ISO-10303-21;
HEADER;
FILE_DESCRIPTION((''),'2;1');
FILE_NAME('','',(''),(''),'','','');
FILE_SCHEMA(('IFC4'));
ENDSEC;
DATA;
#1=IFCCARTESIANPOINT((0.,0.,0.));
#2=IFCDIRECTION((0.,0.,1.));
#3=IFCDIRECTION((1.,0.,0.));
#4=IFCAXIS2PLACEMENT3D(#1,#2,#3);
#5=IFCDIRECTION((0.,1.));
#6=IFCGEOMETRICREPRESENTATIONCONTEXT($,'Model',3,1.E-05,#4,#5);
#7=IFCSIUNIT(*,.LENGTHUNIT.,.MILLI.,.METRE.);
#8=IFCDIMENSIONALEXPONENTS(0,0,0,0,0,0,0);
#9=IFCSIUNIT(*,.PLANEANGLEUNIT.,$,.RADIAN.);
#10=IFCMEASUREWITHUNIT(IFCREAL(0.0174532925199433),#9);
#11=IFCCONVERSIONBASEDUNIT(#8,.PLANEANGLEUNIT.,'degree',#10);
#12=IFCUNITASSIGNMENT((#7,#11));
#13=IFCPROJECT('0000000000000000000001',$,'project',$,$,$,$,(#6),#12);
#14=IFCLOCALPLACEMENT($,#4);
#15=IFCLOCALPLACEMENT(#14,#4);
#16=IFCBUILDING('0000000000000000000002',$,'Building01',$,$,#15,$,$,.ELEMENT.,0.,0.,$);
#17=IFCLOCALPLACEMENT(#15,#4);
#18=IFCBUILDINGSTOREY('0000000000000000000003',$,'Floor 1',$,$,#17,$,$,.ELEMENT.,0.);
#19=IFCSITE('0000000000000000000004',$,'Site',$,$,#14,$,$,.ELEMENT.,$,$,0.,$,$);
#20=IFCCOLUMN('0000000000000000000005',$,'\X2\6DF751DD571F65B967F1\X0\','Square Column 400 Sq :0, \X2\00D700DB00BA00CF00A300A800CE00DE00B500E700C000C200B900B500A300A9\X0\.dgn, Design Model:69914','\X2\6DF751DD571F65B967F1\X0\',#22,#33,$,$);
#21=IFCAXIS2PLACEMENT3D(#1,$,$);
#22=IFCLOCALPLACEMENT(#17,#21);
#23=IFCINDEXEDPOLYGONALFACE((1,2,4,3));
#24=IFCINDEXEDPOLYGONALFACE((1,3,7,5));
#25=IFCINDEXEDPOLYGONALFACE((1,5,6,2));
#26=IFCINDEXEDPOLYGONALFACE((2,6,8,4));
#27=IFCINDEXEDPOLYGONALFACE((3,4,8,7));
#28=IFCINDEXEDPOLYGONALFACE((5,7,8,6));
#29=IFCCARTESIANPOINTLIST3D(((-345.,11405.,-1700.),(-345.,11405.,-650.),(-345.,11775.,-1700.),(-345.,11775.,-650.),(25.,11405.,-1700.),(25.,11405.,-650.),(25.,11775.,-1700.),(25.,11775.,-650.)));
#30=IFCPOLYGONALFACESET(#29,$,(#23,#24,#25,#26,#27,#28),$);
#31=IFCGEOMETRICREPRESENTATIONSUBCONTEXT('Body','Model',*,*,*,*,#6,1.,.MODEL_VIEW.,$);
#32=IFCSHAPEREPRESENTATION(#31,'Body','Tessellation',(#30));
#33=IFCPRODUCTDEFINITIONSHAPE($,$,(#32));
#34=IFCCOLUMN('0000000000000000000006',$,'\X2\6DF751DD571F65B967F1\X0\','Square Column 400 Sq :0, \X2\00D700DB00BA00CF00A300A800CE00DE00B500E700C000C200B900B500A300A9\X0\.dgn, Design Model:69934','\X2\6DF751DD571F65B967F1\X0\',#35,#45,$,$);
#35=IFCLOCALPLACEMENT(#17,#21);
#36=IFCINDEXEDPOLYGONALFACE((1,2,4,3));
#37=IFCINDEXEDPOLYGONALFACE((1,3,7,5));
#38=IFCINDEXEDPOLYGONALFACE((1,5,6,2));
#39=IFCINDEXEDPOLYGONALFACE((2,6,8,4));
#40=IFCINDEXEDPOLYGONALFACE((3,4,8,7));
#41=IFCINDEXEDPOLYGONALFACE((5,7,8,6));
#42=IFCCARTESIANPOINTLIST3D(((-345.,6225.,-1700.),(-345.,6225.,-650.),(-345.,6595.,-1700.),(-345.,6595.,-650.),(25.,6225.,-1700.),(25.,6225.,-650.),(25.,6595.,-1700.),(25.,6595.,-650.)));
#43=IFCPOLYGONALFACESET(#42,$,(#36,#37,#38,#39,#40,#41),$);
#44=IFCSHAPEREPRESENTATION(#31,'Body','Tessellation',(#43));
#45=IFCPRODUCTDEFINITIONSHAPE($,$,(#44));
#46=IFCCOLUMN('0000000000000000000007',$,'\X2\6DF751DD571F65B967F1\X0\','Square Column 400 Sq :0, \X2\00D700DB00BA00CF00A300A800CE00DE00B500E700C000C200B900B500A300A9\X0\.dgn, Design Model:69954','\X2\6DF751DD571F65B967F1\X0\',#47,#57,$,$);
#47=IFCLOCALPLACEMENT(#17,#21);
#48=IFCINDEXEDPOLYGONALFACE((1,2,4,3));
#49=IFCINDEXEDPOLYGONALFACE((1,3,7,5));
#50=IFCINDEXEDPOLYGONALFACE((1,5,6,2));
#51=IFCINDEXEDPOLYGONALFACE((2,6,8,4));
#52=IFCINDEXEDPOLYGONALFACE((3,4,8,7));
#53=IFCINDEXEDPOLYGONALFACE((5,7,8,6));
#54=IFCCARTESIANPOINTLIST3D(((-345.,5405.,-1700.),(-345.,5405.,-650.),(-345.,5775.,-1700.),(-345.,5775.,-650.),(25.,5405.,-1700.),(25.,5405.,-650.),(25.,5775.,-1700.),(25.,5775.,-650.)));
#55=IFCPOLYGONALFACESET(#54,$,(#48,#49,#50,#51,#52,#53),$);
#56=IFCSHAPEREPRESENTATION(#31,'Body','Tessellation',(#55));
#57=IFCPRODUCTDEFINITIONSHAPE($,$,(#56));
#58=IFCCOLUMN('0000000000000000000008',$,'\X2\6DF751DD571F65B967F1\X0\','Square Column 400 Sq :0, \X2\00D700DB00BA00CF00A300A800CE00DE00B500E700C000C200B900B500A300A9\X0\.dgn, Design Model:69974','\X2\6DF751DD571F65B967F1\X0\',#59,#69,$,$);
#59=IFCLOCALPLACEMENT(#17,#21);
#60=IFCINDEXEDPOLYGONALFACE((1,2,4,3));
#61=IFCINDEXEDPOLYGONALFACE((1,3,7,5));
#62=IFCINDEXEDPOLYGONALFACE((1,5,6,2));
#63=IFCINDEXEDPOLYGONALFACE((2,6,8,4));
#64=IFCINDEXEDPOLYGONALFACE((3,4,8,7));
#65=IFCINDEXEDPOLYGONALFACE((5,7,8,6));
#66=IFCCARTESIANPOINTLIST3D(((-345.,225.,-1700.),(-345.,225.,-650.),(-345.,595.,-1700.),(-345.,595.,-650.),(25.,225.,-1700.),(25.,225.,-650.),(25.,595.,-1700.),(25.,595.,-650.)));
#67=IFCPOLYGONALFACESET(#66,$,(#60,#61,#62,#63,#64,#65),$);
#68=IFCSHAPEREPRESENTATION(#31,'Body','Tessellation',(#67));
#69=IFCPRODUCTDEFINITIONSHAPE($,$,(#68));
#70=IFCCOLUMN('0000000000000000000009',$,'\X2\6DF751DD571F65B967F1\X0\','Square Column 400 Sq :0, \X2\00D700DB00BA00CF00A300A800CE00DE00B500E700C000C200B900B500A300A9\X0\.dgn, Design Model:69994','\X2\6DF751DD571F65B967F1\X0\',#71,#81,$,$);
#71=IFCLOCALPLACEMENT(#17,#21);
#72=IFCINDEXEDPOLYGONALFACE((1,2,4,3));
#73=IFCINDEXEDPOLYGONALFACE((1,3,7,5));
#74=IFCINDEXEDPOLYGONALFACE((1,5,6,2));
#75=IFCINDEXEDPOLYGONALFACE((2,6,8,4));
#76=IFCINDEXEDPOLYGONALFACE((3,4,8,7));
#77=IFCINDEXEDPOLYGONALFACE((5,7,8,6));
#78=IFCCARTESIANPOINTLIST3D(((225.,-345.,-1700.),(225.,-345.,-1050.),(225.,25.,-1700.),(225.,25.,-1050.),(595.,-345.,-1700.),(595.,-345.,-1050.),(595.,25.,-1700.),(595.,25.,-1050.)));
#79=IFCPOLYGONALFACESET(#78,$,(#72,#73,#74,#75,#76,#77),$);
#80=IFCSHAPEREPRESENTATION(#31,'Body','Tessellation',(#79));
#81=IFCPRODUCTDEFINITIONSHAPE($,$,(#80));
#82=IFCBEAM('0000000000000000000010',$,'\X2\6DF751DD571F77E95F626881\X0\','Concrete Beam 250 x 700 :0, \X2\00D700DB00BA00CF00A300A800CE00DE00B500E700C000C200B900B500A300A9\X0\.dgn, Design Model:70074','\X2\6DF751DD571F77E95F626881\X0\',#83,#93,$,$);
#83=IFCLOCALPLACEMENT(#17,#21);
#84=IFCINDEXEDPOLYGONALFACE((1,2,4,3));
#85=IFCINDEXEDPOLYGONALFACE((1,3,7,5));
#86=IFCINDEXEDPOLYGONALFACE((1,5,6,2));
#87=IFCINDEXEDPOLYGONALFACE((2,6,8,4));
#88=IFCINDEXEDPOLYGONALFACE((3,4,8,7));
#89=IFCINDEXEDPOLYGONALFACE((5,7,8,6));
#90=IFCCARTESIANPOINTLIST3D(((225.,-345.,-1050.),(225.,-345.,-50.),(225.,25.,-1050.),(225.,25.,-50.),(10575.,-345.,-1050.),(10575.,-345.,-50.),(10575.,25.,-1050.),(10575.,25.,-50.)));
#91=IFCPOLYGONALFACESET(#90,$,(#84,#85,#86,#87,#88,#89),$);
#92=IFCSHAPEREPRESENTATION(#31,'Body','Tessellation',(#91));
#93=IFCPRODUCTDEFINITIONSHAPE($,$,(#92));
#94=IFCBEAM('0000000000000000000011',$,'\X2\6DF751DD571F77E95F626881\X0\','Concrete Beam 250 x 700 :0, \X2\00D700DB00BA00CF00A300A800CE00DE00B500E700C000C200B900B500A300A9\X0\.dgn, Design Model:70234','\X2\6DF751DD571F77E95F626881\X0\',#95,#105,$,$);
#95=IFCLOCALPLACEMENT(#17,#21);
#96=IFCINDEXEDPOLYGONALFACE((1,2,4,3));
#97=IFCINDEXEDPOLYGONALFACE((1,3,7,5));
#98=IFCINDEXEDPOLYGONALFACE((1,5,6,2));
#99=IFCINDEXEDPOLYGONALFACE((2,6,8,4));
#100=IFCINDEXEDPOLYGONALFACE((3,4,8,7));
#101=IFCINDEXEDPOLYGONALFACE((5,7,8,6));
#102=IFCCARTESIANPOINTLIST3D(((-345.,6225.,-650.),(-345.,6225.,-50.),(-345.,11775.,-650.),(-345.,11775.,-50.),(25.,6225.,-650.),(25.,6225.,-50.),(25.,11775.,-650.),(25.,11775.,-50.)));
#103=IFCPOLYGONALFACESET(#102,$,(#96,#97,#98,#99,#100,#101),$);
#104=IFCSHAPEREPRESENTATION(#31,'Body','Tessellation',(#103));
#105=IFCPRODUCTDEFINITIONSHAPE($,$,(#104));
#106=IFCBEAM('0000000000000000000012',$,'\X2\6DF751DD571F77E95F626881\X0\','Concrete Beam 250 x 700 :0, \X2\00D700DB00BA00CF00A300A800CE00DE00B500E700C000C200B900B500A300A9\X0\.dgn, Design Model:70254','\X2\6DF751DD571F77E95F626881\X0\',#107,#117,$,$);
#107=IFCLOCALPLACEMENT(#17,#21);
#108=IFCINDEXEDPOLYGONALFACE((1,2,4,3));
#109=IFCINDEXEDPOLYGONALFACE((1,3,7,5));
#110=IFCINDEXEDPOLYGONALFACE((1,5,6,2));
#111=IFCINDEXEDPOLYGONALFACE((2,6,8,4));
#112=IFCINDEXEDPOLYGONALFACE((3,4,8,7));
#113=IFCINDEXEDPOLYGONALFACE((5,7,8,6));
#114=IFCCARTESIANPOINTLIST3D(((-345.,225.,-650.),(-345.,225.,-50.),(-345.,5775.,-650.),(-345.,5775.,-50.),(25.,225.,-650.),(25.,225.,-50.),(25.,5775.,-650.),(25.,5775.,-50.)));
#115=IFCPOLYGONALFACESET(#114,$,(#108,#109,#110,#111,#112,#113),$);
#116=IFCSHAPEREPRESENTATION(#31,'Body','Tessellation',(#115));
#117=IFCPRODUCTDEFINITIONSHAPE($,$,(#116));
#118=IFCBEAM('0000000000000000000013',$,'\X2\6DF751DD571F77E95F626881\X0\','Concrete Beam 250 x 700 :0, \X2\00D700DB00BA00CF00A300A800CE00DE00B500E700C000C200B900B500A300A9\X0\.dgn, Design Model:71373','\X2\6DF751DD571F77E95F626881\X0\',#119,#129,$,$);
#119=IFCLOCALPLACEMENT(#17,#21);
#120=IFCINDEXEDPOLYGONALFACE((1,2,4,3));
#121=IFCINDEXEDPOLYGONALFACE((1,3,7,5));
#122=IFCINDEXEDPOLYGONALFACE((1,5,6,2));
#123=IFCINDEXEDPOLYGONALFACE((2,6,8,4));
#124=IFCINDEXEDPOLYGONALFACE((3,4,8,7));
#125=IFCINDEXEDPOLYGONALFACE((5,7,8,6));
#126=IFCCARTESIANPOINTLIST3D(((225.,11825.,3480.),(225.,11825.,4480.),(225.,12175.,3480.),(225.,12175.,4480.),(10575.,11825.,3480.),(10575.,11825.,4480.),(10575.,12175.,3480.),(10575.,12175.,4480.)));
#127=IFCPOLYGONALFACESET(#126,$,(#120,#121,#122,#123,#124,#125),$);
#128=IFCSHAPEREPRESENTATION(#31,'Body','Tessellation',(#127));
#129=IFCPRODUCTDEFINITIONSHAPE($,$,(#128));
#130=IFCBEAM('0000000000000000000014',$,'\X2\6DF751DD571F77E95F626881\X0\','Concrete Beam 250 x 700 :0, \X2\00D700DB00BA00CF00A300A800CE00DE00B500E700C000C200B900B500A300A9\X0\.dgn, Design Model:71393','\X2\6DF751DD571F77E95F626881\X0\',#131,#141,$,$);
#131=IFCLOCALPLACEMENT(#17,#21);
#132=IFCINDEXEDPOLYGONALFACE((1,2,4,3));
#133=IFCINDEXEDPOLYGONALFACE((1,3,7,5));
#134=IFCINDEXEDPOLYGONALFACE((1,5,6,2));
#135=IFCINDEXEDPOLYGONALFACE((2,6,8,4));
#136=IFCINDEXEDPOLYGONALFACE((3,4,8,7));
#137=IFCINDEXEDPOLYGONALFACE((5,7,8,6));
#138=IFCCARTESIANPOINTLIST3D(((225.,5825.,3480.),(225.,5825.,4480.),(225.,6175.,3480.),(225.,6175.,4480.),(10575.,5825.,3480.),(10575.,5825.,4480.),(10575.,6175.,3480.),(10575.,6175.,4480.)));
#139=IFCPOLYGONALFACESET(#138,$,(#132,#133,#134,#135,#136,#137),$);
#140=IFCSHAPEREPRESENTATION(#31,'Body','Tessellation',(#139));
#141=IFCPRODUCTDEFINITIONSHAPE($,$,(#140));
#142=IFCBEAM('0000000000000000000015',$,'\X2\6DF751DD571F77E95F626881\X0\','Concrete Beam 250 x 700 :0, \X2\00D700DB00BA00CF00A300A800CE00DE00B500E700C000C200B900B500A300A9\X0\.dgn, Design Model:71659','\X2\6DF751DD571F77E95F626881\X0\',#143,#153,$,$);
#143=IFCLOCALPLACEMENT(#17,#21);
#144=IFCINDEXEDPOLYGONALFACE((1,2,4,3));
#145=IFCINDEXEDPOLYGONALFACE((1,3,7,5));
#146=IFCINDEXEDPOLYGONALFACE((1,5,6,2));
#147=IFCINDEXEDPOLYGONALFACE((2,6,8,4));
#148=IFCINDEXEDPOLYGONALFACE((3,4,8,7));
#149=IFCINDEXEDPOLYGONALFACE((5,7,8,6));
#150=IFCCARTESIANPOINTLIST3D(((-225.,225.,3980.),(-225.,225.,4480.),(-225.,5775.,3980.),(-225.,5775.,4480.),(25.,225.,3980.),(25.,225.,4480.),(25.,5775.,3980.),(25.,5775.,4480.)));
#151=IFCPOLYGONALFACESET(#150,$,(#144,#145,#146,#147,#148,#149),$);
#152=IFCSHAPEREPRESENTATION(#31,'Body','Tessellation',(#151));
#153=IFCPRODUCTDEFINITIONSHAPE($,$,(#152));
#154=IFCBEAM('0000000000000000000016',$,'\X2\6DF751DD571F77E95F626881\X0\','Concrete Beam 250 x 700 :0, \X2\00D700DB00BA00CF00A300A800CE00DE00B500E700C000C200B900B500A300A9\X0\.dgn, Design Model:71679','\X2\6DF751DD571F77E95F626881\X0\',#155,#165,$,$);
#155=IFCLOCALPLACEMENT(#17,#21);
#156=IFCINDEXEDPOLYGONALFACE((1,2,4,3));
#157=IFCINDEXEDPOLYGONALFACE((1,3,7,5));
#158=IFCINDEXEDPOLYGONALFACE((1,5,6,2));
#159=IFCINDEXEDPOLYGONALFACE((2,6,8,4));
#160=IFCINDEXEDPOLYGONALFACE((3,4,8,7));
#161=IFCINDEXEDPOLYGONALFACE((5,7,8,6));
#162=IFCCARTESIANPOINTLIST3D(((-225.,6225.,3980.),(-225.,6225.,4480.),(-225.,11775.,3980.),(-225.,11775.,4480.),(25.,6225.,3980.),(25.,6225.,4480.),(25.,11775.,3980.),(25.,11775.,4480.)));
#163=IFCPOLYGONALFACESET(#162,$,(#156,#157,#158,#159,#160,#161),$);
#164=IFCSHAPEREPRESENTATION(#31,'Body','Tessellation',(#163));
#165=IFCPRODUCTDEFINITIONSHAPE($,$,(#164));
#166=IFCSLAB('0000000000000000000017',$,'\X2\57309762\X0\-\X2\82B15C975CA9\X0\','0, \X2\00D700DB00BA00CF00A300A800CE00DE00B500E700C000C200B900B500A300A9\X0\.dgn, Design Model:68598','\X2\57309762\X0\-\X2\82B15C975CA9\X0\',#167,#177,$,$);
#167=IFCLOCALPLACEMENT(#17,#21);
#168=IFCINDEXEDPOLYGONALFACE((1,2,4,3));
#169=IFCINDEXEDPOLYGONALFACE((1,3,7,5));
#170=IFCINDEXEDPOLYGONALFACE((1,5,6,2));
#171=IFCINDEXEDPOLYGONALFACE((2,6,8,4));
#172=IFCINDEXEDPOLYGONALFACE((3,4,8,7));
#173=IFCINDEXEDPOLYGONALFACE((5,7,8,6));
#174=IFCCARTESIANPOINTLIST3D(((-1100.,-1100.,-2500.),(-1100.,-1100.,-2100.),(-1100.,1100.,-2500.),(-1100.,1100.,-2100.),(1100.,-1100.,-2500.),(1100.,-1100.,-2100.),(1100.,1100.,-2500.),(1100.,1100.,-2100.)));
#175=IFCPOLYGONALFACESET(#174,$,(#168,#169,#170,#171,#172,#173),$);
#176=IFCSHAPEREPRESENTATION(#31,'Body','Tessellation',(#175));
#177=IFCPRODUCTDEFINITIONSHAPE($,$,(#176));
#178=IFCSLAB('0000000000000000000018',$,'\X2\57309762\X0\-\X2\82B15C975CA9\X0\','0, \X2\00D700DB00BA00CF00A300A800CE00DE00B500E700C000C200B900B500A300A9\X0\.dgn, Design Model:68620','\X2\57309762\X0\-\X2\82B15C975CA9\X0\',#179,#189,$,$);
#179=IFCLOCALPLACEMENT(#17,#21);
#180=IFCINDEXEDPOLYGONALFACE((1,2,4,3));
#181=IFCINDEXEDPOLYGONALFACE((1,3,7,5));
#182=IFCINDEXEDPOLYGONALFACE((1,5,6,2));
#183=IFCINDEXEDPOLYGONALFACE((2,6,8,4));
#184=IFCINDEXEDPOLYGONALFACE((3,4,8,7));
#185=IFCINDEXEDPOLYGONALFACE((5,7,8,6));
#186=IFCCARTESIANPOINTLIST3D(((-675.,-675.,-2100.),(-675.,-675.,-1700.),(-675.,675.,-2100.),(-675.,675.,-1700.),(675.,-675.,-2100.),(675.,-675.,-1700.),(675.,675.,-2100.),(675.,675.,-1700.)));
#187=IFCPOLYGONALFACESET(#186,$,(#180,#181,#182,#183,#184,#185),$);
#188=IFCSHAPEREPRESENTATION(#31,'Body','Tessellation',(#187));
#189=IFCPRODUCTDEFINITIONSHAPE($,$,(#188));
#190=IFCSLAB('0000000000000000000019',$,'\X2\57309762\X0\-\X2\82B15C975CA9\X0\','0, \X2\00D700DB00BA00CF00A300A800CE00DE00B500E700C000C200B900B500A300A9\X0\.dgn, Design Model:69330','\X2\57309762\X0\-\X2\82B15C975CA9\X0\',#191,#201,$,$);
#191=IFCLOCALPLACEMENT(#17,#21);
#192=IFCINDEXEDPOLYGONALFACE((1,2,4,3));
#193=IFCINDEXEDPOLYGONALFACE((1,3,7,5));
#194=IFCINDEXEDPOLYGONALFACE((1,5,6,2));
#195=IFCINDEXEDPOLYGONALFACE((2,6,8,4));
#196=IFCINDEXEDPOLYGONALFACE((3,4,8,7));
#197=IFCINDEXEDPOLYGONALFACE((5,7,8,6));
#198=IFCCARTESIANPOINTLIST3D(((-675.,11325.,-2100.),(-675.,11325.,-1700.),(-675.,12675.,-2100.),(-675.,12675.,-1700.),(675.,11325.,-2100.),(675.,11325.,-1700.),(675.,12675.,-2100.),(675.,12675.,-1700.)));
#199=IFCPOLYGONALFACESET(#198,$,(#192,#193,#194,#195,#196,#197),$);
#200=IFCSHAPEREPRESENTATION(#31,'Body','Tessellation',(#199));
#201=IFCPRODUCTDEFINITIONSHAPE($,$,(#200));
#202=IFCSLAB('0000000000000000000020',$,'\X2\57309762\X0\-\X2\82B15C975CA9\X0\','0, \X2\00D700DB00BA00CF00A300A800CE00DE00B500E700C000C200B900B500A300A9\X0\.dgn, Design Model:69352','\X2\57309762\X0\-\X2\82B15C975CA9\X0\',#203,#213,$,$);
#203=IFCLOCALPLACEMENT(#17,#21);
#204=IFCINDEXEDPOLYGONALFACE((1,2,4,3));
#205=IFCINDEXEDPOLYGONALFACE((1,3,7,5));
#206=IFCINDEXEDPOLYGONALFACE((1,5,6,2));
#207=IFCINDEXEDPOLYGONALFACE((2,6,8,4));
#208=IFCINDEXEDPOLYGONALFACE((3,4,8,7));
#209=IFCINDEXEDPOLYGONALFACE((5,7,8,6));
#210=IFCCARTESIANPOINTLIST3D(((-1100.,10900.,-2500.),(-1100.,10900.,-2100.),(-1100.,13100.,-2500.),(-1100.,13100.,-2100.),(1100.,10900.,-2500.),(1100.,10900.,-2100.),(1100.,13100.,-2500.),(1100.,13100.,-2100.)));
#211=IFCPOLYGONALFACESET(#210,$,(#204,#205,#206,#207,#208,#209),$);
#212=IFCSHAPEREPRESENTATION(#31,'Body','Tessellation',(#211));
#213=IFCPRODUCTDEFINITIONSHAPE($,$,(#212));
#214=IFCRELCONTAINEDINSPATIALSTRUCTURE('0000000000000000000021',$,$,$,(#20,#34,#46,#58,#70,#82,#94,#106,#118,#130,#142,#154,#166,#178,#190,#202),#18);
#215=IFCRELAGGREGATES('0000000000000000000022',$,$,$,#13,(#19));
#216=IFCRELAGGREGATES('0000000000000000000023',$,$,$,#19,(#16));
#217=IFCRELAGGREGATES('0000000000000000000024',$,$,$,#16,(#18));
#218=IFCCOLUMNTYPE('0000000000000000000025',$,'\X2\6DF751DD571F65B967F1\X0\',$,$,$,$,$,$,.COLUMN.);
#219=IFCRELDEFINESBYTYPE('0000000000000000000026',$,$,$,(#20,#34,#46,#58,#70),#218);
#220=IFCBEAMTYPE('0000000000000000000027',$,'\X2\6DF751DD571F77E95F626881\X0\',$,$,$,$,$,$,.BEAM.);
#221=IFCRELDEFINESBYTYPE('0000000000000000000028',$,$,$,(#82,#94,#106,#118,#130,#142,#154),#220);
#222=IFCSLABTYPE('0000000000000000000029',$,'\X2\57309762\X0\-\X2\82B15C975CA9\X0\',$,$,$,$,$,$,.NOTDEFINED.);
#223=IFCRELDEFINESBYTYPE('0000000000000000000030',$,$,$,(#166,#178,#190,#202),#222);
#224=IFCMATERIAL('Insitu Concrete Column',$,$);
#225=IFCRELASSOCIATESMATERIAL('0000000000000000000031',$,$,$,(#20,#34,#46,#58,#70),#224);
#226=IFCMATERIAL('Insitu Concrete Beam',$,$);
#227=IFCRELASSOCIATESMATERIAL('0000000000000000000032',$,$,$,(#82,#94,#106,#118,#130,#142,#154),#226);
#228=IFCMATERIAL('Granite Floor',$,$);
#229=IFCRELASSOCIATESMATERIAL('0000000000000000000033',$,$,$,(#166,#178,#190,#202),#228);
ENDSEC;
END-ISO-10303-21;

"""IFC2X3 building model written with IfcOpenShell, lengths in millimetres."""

from ifc_helpers import new_model, entity, si_unit, converted_unit, direction, frame, frame_2d, origin_with_axes, place, context, subcontext, project, spatial, rectangle, extrude, material, type_object, element, save


model = new_model("IFC2X3")

# Units and contexts
model_context = context("Model", 3, precision=1e-05, world=origin_with_axes(), true_north=direction((0.0, 1.0)))
body_context = subcontext(model_context, "Body", "Model", "MODEL_VIEW", scale=1.0)
ifc_project = project(units=[si_unit("LENGTHUNIT", "METRE", prefix="MILLI"), converted_unit("PLANEANGLEUNIT", "degree", entity("IfcReal", 0.0174532925199433), si_unit("PLANEANGLEUNIT", "RADIAN"), dimensions=[0, 0, 0, 0, 0, 0, 0])], contexts=[model_context])

# Site, building, storey
site_placement = place(None, origin_with_axes())
site = spatial("IfcSite", under=ifc_project, at=site_placement, Name="Site", CompositionType="ELEMENT", RefElevation=0.0)
building_placement = place(site_placement, origin_with_axes())
building = spatial("IfcBuilding", under=site, at=building_placement, Name="Building01", CompositionType="ELEMENT", ElevationOfRefHeight=0.0, ElevationOfTerrain=0.0)
storey_placement = place(building_placement, origin_with_axes())
storey = spatial("IfcBuildingStorey", under=building, at=storey_placement, Name="Floor 1", CompositionType="ELEMENT", Elevation=0.0)

# Columns
ifc_material_1 = material(Name="Insitu Concrete Column")
column_type = type_object("IfcColumnType", Name="混凝土方柱", PredefinedType="COLUMN")
for number, where, z_axis, x_axis, name, description in (
    (1, (25.0, 11405.0, -1700.0), (0.0, 0.0, 1.0), (0.0, 1.0, 0.0), "混凝土方柱", "Square Column 400 Sq :0, ×ÛºÏ£¨ÎÞµçÀÂ¹µ£©.dgn, Design Model:69914"),
    (2, (25.0, 6595.0, -1700.0), (0.0, 0.0, 1.0), (-1.0, 0.0, 0.0), "混凝土方柱", "Square Column 400 Sq :0, ×ÛºÏ£¨ÎÞµçÀÂ¹µ£©.dgn, Design Model:69934"),
    (3, (25.0, 5405.0, -1700.0), (0.0, 0.0, 1.0), (0.0, 1.0, 0.0), "混凝土方柱", "Square Column 400 Sq :0, ×ÛºÏ£¨ÎÞµçÀÂ¹µ£©.dgn, Design Model:69954"),
    (4, (25.0, 595.0, -1700.0), (0.0, 0.0, 1.0), (-1.0, 0.0, 0.0), "混凝土方柱", "Square Column 400 Sq :0, ×ÛºÏ£¨ÎÞµçÀÂ¹µ£©.dgn, Design Model:69974"),
):
    element("IfcColumn", number, at=place(storey_placement, frame(where, z_axis=z_axis, x_axis=x_axis)), inside=storey, type_object=column_type, material=ifc_material_1, Name=name, Description=description, ObjectType="混凝土方柱", context=body_context, shape_type="SweptSolid", body=[
        extrude(rectangle(XDim=370.0, YDim=370.0, at=frame_2d((185.0, 185.0), x_axis=(0.0, 1.0))), origin_with_axes(), (0.0, 0.0, 1.0), 1050.0),
    ])
column_placement = place(storey_placement, frame((225.0, 25.0, -1700.0), z_axis=(0.0, 0.0, 1.0), x_axis=(0.0, -1.0, 0.0)))
element("IfcColumn", 5, at=column_placement, inside=storey, type_object=column_type, material=ifc_material_1, Name="混凝土方柱", Description="Square Column 400 Sq :0, ×ÛºÏ£¨ÎÞµçÀÂ¹µ£©.dgn, Design Model:69994", ObjectType="混凝土方柱", context=body_context, shape_type="SweptSolid", body=[
    extrude(rectangle(XDim=370.0, YDim=370.0, at=frame_2d((185.0, 185.0), x_axis=(0.0, 1.0))), origin_with_axes(), (0.0, 0.0, 1.0), 650.0),
])

# Beams
ifc_material_2 = material(Name="Insitu Concrete Beam")
beam_type = type_object("IfcBeamType", Name="混凝土矩形梁", PredefinedType="BEAM")
beam_placement = place(storey_placement, frame((225.0, -345.0, -1050.0), z_axis=(1.0, 0.0, 0.0), x_axis=(0.0, 1.0, 0.0)))
element("IfcBeam", 6, at=beam_placement, inside=storey, type_object=beam_type, material=ifc_material_2, Name="混凝土矩形梁", Description="Concrete Beam 250 x 700 :0, ×ÛºÏ£¨ÎÞµçÀÂ¹µ£©.dgn, Design Model:70074", ObjectType="混凝土矩形梁", context=body_context, shape_type="SweptSolid", body=[
    extrude(rectangle(XDim=1000.0, YDim=370.0, at=frame_2d((185.0, 500.0), x_axis=(0.0, 1.0))), origin_with_axes(), (0.0, 0.0, 1.0), 10350.0),
])
for number, where, z_axis, x_axis, name, description in (
    (7, (-345.0, 6225.0, -650.0), (0.0, 1.0, 0.0), (0.0, 0.0, 1.0), "混凝土矩形梁", "Concrete Beam 250 x 700 :0, ×ÛºÏ£¨ÎÞµçÀÂ¹µ£©.dgn, Design Model:70234"),
    (8, (-345.0, 225.0, -650.0), (0.0, 1.0, 0.0), (0.0, 0.0, 1.0), "混凝土矩形梁", "Concrete Beam 250 x 700 :0, ×ÛºÏ£¨ÎÞµçÀÂ¹µ£©.dgn, Design Model:70254"),
):
    element("IfcBeam", number, at=place(storey_placement, frame(where, z_axis=z_axis, x_axis=x_axis)), inside=storey, type_object=beam_type, material=ifc_material_2, Name=name, Description=description, ObjectType="混凝土矩形梁", context=body_context, shape_type="SweptSolid", body=[
        extrude(rectangle(XDim=370.0, YDim=600.0, at=frame_2d((300.0, 185.0), x_axis=(0.0, 1.0))), origin_with_axes(), (0.0, 0.0, 1.0), 5550.0),
    ])
for number, where, z_axis, x_axis, name, description in (
    (9, (225.0, 11825.0, 3480.0), (1.0, 0.0, 0.0), (0.0, 1.0, 0.0), "混凝土矩形梁", "Concrete Beam 250 x 700 :0, ×ÛºÏ£¨ÎÞµçÀÂ¹µ£©.dgn, Design Model:71373"),
    (10, (225.0, 5825.0, 3480.0), (1.0, 0.0, 0.0), (0.0, 1.0, 0.0), "混凝土矩形梁", "Concrete Beam 250 x 700 :0, ×ÛºÏ£¨ÎÞµçÀÂ¹µ£©.dgn, Design Model:71393"),
):
    element("IfcBeam", number, at=place(storey_placement, frame(where, z_axis=z_axis, x_axis=x_axis)), inside=storey, type_object=beam_type, material=ifc_material_2, Name=name, Description=description, ObjectType="混凝土矩形梁", context=body_context, shape_type="SweptSolid", body=[
        extrude(rectangle(XDim=1000.0, YDim=350.0, at=frame_2d((175.0, 500.0), x_axis=(0.0, 1.0))), origin_with_axes(), (0.0, 0.0, 1.0), 10350.0),
    ])
for number, where, z_axis, x_axis, name, description in (
    (11, (-225.0, 5775.0, 3980.0), (0.0, -1.0, 0.0), (1.0, 0.0, 0.0), "混凝土矩形梁", "Concrete Beam 250 x 700 :0, ×ÛºÏ£¨ÎÞµçÀÂ¹µ£©.dgn, Design Model:71659"),
    (12, (-225.0, 11775.0, 3980.0), (0.0, -1.0, 0.0), (1.0, 0.0, 0.0), "混凝土矩形梁", "Concrete Beam 250 x 700 :0, ×ÛºÏ£¨ÎÞµçÀÂ¹µ£©.dgn, Design Model:71679"),
):
    element("IfcBeam", number, at=place(storey_placement, frame(where, z_axis=z_axis, x_axis=x_axis)), inside=storey, type_object=beam_type, material=ifc_material_2, Name=name, Description=description, ObjectType="混凝土矩形梁", context=body_context, shape_type="SweptSolid", body=[
        extrude(rectangle(XDim=500.0, YDim=250.0, at=frame_2d((125.0, 250.0), x_axis=(0.0, 1.0))), origin_with_axes(), (0.0, 0.0, 1.0), 5550.0),
    ])

# Slabs
ifc_material_3 = material(Name="Granite Floor")
slab_type = type_object("IfcSlabType", Name="地面-花岗岩", PredefinedType="NOTDEFINED")
slab_1_placement = place(storey_placement, frame((-1100.0, -1100.0, -2500.0), z_axis=(0.0, 0.0, 1.0), x_axis=(1.0, 0.0, 0.0)))
element("IfcSlab", 13, at=slab_1_placement, inside=storey, type_object=slab_type, material=ifc_material_3, Name="地面-花岗岩", Description="0, ×ÛºÏ£¨ÎÞµçÀÂ¹µ£©.dgn, Design Model:68598", ObjectType="地面-花岗岩", context=body_context, shape_type="SweptSolid", body=[
    extrude(rectangle(XDim=2200.0, YDim=2200.0, at=frame_2d((1100.0, 1100.0), x_axis=(1.0, 0.0))), origin_with_axes(), (0.0, 0.0, 1.0), 400.0),
])
for number, where, z_axis, x_axis, name in (
    (14, (-675.0, -675.0, -2100.0), (0.0, 0.0, 1.0), (1.0, 0.0, 0.0), "地面-花岗岩"),
):
    element("IfcSlab", number, at=place(storey_placement, frame(where, z_axis=z_axis, x_axis=x_axis)), inside=storey, type_object=slab_type, material=ifc_material_3, Name=name, Description="0, ×ÛºÏ£¨ÎÞµçÀÂ¹µ£©.dgn, Design Model:68620", ObjectType="地面-花岗岩", context=body_context, shape_type="SweptSolid", body=[
        extrude(rectangle(XDim=1350.0, YDim=1350.0, at=frame_2d((675.0, 675.0), x_axis=(1.0, 0.0))), origin_with_axes(), (0.0, 0.0, 1.0), 400.0),
    ])
slab_2_placement = place(storey_placement, frame((-675.0, 11325.0, -2100.0), z_axis=(0.0, 0.0, 1.0), x_axis=(1.0, 0.0, 0.0)))
element("IfcSlab", 15, at=slab_2_placement, inside=storey, type_object=slab_type, material=ifc_material_3, Name="地面-花岗岩", Description="0, ×ÛºÏ£¨ÎÞµçÀÂ¹µ£©.dgn, Design Model:69330", ObjectType="地面-花岗岩", context=body_context, shape_type="SweptSolid", body=[
    extrude(rectangle(XDim=1350.0, YDim=1350.0, at=frame_2d((675.0, 675.0), x_axis=(1.0, 0.0))), origin_with_axes(), (0.0, 0.0, 1.0), 400.0),
])
slab_3_placement = place(storey_placement, frame((-1100.0, 10900.0, -2500.0), z_axis=(0.0, 0.0, 1.0), x_axis=(1.0, 0.0, 0.0)))
element("IfcSlab", 16, at=slab_3_placement, inside=storey, type_object=slab_type, material=ifc_material_3, Name="地面-花岗岩", Description="0, ×ÛºÏ£¨ÎÞµçÀÂ¹µ£©.dgn, Design Model:69352", ObjectType="地面-花岗岩", context=body_context, shape_type="SweptSolid", body=[
    extrude(rectangle(XDim=2200.0, YDim=2200.0, at=frame_2d((1100.0, 1100.0), x_axis=(1.0, 0.0))), origin_with_axes(), (0.0, 0.0, 1.0), 400.0),
])

save(model, "model.ifc")
